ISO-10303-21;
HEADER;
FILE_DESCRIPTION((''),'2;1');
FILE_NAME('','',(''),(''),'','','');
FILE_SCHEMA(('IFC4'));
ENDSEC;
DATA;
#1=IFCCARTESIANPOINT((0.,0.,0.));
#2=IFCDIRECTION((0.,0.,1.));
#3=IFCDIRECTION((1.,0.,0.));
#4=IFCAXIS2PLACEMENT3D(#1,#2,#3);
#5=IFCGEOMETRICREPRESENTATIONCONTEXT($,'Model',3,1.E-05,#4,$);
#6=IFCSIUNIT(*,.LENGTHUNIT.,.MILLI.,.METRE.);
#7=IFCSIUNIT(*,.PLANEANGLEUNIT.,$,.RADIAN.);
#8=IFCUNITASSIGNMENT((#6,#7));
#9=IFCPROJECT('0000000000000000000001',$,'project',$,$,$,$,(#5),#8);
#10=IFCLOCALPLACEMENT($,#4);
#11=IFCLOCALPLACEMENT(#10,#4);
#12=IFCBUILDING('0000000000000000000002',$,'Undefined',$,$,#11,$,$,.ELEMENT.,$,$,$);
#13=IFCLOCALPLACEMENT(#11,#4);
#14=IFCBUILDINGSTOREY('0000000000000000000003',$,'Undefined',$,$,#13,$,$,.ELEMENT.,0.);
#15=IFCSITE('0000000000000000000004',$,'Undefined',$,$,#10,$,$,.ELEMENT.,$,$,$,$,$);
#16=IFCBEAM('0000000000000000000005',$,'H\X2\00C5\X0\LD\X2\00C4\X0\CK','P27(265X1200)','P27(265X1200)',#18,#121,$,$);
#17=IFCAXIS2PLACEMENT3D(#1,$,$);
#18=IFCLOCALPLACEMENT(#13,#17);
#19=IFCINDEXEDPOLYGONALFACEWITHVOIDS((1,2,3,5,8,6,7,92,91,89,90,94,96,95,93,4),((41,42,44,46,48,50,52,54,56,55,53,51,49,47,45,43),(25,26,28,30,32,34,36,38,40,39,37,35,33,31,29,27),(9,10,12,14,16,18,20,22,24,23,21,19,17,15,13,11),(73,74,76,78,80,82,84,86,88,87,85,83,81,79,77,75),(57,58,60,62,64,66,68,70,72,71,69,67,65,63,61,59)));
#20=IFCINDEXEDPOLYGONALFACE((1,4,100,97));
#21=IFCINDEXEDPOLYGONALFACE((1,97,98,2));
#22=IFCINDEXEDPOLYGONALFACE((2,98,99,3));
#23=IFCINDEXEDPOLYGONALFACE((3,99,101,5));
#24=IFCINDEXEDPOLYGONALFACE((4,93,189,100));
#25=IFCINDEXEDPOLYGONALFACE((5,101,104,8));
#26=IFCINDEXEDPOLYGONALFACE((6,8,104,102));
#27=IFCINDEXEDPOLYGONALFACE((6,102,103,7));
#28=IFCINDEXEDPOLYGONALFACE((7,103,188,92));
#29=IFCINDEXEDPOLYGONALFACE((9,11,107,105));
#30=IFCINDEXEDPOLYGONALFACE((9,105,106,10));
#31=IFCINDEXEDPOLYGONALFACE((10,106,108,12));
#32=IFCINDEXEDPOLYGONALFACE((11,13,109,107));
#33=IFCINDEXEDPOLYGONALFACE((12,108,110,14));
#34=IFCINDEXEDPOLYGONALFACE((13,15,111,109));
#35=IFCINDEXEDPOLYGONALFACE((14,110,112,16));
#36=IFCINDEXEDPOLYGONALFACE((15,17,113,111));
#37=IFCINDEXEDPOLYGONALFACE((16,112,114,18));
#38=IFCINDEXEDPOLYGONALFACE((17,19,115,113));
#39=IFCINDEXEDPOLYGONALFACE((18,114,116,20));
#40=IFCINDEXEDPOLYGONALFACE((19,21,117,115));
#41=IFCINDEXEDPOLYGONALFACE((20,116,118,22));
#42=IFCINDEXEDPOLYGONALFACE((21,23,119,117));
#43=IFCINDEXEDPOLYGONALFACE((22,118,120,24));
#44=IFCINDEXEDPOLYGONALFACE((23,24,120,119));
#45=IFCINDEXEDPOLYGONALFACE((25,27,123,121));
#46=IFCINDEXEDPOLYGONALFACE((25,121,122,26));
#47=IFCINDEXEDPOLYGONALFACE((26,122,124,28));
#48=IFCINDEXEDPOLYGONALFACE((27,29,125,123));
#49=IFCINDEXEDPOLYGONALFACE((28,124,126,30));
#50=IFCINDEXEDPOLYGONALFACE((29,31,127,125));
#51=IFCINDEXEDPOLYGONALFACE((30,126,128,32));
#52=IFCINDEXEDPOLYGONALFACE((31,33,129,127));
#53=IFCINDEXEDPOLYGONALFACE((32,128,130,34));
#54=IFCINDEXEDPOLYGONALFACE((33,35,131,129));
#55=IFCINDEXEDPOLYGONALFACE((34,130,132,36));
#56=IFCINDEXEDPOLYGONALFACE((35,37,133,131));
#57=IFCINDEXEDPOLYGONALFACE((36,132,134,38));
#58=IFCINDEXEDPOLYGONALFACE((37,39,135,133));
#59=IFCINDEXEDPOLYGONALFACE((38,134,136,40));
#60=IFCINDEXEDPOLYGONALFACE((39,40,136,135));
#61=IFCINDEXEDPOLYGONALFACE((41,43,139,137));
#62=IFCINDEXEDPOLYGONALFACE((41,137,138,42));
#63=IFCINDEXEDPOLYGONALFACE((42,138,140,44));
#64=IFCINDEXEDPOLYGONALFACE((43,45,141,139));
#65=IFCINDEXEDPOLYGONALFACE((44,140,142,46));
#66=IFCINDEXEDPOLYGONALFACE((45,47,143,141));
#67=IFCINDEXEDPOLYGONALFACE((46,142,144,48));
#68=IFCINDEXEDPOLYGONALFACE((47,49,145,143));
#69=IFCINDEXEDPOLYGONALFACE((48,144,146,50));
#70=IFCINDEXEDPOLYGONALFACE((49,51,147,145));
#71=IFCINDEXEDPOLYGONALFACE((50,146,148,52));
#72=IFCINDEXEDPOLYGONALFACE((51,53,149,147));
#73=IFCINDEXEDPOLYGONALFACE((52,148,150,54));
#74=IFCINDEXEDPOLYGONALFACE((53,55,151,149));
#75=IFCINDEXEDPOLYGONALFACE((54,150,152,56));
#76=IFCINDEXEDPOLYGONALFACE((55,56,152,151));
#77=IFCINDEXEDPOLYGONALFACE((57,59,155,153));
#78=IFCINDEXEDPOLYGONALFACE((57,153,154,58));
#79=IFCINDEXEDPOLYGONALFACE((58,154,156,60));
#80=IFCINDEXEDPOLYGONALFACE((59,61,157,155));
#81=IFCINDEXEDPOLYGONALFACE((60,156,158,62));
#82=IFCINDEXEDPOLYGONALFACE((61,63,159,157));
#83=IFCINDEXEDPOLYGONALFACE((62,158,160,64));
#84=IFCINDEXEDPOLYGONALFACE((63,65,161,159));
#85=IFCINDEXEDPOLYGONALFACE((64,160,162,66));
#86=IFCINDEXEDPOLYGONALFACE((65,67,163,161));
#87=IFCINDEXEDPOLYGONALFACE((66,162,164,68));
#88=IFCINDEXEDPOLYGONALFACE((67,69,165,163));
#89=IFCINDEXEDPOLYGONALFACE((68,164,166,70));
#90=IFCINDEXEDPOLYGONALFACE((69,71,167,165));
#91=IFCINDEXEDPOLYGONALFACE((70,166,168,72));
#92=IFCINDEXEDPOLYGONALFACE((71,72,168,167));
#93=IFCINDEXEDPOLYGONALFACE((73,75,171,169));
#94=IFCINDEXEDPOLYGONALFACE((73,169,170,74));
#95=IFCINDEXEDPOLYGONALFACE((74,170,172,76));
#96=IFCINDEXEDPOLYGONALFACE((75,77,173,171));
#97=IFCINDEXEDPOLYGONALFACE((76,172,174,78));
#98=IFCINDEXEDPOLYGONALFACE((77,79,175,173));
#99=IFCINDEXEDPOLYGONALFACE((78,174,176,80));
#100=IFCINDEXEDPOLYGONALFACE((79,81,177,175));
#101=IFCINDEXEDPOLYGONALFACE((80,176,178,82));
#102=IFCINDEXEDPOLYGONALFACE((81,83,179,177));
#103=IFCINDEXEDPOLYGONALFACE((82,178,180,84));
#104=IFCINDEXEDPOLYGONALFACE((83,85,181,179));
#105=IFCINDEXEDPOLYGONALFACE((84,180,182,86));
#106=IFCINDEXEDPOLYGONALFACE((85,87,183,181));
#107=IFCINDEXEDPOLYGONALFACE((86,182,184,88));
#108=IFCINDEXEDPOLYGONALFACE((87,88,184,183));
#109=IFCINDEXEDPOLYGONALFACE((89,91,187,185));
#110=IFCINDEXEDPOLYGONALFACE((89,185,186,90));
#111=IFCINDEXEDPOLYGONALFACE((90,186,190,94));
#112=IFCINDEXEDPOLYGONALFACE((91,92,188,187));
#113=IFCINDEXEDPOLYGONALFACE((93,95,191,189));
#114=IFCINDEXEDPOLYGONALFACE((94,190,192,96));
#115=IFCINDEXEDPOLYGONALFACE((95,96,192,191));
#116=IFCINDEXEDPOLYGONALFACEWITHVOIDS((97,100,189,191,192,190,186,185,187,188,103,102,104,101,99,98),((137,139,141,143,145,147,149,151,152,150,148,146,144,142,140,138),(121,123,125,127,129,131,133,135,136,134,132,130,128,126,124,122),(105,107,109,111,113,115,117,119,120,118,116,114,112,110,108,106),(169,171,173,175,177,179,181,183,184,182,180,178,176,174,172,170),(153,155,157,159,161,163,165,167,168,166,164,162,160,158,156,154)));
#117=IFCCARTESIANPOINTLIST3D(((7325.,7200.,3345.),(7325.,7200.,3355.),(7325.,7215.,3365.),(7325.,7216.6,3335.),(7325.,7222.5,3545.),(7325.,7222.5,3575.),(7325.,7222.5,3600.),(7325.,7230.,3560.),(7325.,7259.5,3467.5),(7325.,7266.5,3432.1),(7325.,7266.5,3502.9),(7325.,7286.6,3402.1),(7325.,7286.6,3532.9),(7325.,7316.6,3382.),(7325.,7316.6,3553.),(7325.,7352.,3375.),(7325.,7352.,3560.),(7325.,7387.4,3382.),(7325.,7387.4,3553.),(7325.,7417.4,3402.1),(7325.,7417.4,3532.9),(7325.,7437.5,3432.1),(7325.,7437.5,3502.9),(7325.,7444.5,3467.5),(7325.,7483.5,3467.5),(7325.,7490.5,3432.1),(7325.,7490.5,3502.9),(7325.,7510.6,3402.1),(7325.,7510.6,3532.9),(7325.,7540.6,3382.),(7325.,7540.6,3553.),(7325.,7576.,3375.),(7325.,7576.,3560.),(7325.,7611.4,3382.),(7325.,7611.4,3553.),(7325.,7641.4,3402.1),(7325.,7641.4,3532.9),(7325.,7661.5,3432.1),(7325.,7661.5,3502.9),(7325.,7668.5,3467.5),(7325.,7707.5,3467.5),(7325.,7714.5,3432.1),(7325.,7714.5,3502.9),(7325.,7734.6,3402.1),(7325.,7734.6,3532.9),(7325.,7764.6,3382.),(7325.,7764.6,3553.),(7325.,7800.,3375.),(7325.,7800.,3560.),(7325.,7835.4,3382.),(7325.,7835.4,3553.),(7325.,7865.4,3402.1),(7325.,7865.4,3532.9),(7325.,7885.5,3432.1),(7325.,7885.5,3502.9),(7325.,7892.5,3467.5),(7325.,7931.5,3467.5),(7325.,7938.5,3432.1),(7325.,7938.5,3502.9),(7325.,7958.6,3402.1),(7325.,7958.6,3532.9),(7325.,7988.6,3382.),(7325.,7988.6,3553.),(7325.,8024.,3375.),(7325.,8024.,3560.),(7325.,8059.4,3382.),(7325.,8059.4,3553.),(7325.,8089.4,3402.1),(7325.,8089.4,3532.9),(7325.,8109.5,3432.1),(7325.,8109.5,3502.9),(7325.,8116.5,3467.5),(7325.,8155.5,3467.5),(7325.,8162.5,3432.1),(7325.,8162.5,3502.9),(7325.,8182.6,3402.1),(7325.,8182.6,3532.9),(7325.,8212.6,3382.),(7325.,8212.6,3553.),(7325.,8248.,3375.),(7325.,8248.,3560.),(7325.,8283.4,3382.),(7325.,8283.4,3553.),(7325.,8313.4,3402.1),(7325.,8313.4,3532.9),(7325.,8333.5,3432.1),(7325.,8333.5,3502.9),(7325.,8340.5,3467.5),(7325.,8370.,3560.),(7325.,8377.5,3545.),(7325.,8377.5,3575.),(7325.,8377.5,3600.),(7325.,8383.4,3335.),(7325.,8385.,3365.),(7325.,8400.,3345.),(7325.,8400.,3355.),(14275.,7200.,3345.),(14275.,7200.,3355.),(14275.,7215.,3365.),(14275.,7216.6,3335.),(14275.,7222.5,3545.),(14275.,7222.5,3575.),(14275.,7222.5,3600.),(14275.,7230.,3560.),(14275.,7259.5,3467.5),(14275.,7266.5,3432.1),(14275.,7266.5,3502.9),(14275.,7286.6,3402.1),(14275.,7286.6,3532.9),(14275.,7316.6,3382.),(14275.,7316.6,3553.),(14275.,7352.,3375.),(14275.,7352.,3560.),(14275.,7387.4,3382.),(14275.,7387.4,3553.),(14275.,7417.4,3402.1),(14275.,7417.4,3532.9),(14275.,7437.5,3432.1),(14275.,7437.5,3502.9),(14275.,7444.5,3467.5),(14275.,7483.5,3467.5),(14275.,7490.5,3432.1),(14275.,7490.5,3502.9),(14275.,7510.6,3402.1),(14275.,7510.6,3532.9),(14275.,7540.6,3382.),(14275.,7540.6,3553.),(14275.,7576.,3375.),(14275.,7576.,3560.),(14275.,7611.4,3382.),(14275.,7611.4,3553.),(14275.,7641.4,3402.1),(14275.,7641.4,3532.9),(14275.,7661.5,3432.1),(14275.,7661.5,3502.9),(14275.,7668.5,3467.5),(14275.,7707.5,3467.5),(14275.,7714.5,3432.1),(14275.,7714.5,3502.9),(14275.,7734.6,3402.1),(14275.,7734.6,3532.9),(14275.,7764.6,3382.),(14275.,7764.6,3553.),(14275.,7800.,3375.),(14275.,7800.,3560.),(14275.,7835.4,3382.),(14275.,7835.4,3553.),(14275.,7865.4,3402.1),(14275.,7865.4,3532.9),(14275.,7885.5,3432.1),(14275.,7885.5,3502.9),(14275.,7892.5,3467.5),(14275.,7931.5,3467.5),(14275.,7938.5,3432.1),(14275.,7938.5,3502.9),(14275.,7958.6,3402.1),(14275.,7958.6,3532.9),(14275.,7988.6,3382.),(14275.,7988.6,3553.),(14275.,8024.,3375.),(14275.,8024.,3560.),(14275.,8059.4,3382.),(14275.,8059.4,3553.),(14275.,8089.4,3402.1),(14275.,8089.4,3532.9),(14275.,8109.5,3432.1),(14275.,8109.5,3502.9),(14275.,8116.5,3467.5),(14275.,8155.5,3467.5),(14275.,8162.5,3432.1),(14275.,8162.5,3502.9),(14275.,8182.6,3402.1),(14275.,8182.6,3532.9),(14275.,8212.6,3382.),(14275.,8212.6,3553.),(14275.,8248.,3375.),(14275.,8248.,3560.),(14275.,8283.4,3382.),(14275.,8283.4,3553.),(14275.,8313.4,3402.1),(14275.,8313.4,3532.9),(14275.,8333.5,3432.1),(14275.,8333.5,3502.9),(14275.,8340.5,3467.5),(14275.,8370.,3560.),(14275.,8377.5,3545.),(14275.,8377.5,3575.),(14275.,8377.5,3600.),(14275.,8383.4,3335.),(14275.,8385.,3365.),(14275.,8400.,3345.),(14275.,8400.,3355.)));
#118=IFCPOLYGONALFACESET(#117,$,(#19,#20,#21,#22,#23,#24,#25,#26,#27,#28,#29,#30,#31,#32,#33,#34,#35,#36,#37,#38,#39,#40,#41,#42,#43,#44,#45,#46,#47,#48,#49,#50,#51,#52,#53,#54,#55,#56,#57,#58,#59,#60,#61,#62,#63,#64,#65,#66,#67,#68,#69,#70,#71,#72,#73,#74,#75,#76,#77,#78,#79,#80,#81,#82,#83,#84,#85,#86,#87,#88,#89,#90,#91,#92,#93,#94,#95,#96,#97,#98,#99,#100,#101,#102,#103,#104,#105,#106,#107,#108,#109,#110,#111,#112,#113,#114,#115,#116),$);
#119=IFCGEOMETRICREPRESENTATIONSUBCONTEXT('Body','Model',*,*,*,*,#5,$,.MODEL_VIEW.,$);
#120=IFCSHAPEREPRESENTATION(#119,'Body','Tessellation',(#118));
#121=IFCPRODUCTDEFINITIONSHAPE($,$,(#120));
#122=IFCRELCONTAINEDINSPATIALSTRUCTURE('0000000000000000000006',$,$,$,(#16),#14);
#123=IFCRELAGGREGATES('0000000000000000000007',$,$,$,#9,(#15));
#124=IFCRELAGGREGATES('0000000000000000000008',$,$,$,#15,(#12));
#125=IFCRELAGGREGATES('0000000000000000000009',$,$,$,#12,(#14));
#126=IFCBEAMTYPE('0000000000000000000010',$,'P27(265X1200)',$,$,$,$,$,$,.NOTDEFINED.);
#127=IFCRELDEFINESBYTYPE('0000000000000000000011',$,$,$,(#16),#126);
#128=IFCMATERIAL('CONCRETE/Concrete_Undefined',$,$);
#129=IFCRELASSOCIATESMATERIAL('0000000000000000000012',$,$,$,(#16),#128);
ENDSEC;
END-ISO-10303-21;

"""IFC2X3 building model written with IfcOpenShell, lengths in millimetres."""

from ifc_helpers import new_model, si_unit, frame, origin_with_axes, place, context, subcontext, project, spatial, polyline, outline, extrude, material, type_object, element, save


model = new_model("IFC2X3")

# Units and contexts
model_context = context("Model", 3, precision=1e-05, world=origin_with_axes())
body_context = subcontext(model_context, "Body", "Model", "MODEL_VIEW")
ifc_project = project(units=[si_unit("LENGTHUNIT", "METRE", prefix="MILLI"), si_unit("PLANEANGLEUNIT", "RADIAN")], contexts=[model_context])

# Site, building, storey
site_placement = place(None, origin_with_axes())
site = spatial("IfcSite", under=ifc_project, at=site_placement, Name="Undefined", CompositionType="ELEMENT")
building_placement = place(site_placement, origin_with_axes())
building = spatial("IfcBuilding", under=site, at=building_placement, Name="Undefined", CompositionType="ELEMENT")
storey_placement = place(building_placement, origin_with_axes())
storey = spatial("IfcBuildingStorey", under=building, at=storey_placement, Name="Undefined", CompositionType="ELEMENT", Elevation=0.0)

# Beam
ifc_material_1 = material(Name="CONCRETE/Concrete_Undefined")
beam_type_1 = type_object("IfcBeamType", Name="P27(265X1200)", PredefinedType="NOTDEFINED")
beam_1_placement = place(storey_placement, frame((7325.0, 7800.0, 3467.5), z_axis=(0.0, 0.0, 1.0), x_axis=(1.0, 0.0, 0.0)))
element("IfcBeam", 1, at=beam_1_placement, inside=storey, type_object=beam_type_1, material=ifc_material_1, Name="HÅLDÄCK", Description="P27(265X1200)", ObjectType="P27(265X1200)", context=body_context, shape_type="SweptSolid", body=[
    extrude(outline(polyline([(-583.4, -132.5), (-600.0, -122.5), (-600.0, -112.5), (-585.0, -102.5), (-577.5, 77.5), (-570.0, 92.5), (-577.5, 107.5), (-577.5, 132.5), (577.5, 132.5), (577.5, 107.5), (570.0, 92.5), (577.5, 77.5), (585.0, -102.5), (600.0, -112.5), (600.0, -122.5), (583.4, -132.5), (-583.4, -132.5)]), holes=[polyline([(-513.4, 65.4), (-533.5, 35.4), (-540.5, 0.0), (-533.5, -35.4), (-513.4, -65.4), (-483.4, -85.5), (-448.0, -92.5), (-412.6, -85.5), (-382.6, -65.4), (-362.5, -35.4), (-355.5, 0.0), (-362.5, 35.4), (-382.6, 65.4), (-412.6, 85.5), (-448.0, 92.5), (-483.4, 85.5), (-513.4, 65.4)]), polyline([(-289.4, 65.4), (-309.5, 35.4), (-316.5, 0.0), (-309.5, -35.4), (-289.4, -65.4), (-259.4, -85.5), (-224.0, -92.5), (-188.6, -85.5), (-158.6, -65.4), (-138.5, -35.4), (-131.5, 0.0), (-138.5, 35.4), (-158.6, 65.4), (-188.6, 85.5), (-224.0, 92.5), (-259.4, 85.5), (-289.4, 65.4)]), polyline([(-65.4, 65.4), (-85.5, 35.4), (-92.5, 0.0), (-85.5, -35.4), (-65.4, -65.4), (-35.4, -85.5), (0.0, -92.5), (35.4, -85.5), (65.4, -65.4), (85.5, -35.4), (92.5, 0.0), (85.5, 35.4), (65.4, 65.4), (35.4, 85.5), (0.0, 92.5), (-35.4, 85.5), (-65.4, 65.4)]), polyline([(158.6, 65.4), (138.5, 35.4), (131.5, 0.0), (138.5, -35.4), (158.6, -65.4), (188.6, -85.5), (224.0, -92.5), (259.4, -85.5), (289.4, -65.4), (309.5, -35.4), (316.5, 0.0), (309.5, 35.4), (289.4, 65.4), (259.4, 85.5), (224.0, 92.5), (188.6, 85.5), (158.6, 65.4)]), polyline([(382.6, 65.4), (362.5, 35.4), (355.5, 0.0), (362.5, -35.4), (382.6, -65.4), (412.6, -85.5), (448.0, -92.5), (483.4, -85.5), (513.4, -65.4), (533.5, -35.4), (540.5, 0.0), (533.5, 35.4), (513.4, 65.4), (483.4, 85.5), (448.0, 92.5), (412.6, 85.5), (382.6, 65.4)])]), frame((6950.0, 0.0, 0.0), z_axis=(-1.0, 0.0, 0.0), x_axis=(0.0, -1.0, 0.0)), (0.0, 0.0, 1.0), 6950.0),
])

save(model, "model.ifc")
